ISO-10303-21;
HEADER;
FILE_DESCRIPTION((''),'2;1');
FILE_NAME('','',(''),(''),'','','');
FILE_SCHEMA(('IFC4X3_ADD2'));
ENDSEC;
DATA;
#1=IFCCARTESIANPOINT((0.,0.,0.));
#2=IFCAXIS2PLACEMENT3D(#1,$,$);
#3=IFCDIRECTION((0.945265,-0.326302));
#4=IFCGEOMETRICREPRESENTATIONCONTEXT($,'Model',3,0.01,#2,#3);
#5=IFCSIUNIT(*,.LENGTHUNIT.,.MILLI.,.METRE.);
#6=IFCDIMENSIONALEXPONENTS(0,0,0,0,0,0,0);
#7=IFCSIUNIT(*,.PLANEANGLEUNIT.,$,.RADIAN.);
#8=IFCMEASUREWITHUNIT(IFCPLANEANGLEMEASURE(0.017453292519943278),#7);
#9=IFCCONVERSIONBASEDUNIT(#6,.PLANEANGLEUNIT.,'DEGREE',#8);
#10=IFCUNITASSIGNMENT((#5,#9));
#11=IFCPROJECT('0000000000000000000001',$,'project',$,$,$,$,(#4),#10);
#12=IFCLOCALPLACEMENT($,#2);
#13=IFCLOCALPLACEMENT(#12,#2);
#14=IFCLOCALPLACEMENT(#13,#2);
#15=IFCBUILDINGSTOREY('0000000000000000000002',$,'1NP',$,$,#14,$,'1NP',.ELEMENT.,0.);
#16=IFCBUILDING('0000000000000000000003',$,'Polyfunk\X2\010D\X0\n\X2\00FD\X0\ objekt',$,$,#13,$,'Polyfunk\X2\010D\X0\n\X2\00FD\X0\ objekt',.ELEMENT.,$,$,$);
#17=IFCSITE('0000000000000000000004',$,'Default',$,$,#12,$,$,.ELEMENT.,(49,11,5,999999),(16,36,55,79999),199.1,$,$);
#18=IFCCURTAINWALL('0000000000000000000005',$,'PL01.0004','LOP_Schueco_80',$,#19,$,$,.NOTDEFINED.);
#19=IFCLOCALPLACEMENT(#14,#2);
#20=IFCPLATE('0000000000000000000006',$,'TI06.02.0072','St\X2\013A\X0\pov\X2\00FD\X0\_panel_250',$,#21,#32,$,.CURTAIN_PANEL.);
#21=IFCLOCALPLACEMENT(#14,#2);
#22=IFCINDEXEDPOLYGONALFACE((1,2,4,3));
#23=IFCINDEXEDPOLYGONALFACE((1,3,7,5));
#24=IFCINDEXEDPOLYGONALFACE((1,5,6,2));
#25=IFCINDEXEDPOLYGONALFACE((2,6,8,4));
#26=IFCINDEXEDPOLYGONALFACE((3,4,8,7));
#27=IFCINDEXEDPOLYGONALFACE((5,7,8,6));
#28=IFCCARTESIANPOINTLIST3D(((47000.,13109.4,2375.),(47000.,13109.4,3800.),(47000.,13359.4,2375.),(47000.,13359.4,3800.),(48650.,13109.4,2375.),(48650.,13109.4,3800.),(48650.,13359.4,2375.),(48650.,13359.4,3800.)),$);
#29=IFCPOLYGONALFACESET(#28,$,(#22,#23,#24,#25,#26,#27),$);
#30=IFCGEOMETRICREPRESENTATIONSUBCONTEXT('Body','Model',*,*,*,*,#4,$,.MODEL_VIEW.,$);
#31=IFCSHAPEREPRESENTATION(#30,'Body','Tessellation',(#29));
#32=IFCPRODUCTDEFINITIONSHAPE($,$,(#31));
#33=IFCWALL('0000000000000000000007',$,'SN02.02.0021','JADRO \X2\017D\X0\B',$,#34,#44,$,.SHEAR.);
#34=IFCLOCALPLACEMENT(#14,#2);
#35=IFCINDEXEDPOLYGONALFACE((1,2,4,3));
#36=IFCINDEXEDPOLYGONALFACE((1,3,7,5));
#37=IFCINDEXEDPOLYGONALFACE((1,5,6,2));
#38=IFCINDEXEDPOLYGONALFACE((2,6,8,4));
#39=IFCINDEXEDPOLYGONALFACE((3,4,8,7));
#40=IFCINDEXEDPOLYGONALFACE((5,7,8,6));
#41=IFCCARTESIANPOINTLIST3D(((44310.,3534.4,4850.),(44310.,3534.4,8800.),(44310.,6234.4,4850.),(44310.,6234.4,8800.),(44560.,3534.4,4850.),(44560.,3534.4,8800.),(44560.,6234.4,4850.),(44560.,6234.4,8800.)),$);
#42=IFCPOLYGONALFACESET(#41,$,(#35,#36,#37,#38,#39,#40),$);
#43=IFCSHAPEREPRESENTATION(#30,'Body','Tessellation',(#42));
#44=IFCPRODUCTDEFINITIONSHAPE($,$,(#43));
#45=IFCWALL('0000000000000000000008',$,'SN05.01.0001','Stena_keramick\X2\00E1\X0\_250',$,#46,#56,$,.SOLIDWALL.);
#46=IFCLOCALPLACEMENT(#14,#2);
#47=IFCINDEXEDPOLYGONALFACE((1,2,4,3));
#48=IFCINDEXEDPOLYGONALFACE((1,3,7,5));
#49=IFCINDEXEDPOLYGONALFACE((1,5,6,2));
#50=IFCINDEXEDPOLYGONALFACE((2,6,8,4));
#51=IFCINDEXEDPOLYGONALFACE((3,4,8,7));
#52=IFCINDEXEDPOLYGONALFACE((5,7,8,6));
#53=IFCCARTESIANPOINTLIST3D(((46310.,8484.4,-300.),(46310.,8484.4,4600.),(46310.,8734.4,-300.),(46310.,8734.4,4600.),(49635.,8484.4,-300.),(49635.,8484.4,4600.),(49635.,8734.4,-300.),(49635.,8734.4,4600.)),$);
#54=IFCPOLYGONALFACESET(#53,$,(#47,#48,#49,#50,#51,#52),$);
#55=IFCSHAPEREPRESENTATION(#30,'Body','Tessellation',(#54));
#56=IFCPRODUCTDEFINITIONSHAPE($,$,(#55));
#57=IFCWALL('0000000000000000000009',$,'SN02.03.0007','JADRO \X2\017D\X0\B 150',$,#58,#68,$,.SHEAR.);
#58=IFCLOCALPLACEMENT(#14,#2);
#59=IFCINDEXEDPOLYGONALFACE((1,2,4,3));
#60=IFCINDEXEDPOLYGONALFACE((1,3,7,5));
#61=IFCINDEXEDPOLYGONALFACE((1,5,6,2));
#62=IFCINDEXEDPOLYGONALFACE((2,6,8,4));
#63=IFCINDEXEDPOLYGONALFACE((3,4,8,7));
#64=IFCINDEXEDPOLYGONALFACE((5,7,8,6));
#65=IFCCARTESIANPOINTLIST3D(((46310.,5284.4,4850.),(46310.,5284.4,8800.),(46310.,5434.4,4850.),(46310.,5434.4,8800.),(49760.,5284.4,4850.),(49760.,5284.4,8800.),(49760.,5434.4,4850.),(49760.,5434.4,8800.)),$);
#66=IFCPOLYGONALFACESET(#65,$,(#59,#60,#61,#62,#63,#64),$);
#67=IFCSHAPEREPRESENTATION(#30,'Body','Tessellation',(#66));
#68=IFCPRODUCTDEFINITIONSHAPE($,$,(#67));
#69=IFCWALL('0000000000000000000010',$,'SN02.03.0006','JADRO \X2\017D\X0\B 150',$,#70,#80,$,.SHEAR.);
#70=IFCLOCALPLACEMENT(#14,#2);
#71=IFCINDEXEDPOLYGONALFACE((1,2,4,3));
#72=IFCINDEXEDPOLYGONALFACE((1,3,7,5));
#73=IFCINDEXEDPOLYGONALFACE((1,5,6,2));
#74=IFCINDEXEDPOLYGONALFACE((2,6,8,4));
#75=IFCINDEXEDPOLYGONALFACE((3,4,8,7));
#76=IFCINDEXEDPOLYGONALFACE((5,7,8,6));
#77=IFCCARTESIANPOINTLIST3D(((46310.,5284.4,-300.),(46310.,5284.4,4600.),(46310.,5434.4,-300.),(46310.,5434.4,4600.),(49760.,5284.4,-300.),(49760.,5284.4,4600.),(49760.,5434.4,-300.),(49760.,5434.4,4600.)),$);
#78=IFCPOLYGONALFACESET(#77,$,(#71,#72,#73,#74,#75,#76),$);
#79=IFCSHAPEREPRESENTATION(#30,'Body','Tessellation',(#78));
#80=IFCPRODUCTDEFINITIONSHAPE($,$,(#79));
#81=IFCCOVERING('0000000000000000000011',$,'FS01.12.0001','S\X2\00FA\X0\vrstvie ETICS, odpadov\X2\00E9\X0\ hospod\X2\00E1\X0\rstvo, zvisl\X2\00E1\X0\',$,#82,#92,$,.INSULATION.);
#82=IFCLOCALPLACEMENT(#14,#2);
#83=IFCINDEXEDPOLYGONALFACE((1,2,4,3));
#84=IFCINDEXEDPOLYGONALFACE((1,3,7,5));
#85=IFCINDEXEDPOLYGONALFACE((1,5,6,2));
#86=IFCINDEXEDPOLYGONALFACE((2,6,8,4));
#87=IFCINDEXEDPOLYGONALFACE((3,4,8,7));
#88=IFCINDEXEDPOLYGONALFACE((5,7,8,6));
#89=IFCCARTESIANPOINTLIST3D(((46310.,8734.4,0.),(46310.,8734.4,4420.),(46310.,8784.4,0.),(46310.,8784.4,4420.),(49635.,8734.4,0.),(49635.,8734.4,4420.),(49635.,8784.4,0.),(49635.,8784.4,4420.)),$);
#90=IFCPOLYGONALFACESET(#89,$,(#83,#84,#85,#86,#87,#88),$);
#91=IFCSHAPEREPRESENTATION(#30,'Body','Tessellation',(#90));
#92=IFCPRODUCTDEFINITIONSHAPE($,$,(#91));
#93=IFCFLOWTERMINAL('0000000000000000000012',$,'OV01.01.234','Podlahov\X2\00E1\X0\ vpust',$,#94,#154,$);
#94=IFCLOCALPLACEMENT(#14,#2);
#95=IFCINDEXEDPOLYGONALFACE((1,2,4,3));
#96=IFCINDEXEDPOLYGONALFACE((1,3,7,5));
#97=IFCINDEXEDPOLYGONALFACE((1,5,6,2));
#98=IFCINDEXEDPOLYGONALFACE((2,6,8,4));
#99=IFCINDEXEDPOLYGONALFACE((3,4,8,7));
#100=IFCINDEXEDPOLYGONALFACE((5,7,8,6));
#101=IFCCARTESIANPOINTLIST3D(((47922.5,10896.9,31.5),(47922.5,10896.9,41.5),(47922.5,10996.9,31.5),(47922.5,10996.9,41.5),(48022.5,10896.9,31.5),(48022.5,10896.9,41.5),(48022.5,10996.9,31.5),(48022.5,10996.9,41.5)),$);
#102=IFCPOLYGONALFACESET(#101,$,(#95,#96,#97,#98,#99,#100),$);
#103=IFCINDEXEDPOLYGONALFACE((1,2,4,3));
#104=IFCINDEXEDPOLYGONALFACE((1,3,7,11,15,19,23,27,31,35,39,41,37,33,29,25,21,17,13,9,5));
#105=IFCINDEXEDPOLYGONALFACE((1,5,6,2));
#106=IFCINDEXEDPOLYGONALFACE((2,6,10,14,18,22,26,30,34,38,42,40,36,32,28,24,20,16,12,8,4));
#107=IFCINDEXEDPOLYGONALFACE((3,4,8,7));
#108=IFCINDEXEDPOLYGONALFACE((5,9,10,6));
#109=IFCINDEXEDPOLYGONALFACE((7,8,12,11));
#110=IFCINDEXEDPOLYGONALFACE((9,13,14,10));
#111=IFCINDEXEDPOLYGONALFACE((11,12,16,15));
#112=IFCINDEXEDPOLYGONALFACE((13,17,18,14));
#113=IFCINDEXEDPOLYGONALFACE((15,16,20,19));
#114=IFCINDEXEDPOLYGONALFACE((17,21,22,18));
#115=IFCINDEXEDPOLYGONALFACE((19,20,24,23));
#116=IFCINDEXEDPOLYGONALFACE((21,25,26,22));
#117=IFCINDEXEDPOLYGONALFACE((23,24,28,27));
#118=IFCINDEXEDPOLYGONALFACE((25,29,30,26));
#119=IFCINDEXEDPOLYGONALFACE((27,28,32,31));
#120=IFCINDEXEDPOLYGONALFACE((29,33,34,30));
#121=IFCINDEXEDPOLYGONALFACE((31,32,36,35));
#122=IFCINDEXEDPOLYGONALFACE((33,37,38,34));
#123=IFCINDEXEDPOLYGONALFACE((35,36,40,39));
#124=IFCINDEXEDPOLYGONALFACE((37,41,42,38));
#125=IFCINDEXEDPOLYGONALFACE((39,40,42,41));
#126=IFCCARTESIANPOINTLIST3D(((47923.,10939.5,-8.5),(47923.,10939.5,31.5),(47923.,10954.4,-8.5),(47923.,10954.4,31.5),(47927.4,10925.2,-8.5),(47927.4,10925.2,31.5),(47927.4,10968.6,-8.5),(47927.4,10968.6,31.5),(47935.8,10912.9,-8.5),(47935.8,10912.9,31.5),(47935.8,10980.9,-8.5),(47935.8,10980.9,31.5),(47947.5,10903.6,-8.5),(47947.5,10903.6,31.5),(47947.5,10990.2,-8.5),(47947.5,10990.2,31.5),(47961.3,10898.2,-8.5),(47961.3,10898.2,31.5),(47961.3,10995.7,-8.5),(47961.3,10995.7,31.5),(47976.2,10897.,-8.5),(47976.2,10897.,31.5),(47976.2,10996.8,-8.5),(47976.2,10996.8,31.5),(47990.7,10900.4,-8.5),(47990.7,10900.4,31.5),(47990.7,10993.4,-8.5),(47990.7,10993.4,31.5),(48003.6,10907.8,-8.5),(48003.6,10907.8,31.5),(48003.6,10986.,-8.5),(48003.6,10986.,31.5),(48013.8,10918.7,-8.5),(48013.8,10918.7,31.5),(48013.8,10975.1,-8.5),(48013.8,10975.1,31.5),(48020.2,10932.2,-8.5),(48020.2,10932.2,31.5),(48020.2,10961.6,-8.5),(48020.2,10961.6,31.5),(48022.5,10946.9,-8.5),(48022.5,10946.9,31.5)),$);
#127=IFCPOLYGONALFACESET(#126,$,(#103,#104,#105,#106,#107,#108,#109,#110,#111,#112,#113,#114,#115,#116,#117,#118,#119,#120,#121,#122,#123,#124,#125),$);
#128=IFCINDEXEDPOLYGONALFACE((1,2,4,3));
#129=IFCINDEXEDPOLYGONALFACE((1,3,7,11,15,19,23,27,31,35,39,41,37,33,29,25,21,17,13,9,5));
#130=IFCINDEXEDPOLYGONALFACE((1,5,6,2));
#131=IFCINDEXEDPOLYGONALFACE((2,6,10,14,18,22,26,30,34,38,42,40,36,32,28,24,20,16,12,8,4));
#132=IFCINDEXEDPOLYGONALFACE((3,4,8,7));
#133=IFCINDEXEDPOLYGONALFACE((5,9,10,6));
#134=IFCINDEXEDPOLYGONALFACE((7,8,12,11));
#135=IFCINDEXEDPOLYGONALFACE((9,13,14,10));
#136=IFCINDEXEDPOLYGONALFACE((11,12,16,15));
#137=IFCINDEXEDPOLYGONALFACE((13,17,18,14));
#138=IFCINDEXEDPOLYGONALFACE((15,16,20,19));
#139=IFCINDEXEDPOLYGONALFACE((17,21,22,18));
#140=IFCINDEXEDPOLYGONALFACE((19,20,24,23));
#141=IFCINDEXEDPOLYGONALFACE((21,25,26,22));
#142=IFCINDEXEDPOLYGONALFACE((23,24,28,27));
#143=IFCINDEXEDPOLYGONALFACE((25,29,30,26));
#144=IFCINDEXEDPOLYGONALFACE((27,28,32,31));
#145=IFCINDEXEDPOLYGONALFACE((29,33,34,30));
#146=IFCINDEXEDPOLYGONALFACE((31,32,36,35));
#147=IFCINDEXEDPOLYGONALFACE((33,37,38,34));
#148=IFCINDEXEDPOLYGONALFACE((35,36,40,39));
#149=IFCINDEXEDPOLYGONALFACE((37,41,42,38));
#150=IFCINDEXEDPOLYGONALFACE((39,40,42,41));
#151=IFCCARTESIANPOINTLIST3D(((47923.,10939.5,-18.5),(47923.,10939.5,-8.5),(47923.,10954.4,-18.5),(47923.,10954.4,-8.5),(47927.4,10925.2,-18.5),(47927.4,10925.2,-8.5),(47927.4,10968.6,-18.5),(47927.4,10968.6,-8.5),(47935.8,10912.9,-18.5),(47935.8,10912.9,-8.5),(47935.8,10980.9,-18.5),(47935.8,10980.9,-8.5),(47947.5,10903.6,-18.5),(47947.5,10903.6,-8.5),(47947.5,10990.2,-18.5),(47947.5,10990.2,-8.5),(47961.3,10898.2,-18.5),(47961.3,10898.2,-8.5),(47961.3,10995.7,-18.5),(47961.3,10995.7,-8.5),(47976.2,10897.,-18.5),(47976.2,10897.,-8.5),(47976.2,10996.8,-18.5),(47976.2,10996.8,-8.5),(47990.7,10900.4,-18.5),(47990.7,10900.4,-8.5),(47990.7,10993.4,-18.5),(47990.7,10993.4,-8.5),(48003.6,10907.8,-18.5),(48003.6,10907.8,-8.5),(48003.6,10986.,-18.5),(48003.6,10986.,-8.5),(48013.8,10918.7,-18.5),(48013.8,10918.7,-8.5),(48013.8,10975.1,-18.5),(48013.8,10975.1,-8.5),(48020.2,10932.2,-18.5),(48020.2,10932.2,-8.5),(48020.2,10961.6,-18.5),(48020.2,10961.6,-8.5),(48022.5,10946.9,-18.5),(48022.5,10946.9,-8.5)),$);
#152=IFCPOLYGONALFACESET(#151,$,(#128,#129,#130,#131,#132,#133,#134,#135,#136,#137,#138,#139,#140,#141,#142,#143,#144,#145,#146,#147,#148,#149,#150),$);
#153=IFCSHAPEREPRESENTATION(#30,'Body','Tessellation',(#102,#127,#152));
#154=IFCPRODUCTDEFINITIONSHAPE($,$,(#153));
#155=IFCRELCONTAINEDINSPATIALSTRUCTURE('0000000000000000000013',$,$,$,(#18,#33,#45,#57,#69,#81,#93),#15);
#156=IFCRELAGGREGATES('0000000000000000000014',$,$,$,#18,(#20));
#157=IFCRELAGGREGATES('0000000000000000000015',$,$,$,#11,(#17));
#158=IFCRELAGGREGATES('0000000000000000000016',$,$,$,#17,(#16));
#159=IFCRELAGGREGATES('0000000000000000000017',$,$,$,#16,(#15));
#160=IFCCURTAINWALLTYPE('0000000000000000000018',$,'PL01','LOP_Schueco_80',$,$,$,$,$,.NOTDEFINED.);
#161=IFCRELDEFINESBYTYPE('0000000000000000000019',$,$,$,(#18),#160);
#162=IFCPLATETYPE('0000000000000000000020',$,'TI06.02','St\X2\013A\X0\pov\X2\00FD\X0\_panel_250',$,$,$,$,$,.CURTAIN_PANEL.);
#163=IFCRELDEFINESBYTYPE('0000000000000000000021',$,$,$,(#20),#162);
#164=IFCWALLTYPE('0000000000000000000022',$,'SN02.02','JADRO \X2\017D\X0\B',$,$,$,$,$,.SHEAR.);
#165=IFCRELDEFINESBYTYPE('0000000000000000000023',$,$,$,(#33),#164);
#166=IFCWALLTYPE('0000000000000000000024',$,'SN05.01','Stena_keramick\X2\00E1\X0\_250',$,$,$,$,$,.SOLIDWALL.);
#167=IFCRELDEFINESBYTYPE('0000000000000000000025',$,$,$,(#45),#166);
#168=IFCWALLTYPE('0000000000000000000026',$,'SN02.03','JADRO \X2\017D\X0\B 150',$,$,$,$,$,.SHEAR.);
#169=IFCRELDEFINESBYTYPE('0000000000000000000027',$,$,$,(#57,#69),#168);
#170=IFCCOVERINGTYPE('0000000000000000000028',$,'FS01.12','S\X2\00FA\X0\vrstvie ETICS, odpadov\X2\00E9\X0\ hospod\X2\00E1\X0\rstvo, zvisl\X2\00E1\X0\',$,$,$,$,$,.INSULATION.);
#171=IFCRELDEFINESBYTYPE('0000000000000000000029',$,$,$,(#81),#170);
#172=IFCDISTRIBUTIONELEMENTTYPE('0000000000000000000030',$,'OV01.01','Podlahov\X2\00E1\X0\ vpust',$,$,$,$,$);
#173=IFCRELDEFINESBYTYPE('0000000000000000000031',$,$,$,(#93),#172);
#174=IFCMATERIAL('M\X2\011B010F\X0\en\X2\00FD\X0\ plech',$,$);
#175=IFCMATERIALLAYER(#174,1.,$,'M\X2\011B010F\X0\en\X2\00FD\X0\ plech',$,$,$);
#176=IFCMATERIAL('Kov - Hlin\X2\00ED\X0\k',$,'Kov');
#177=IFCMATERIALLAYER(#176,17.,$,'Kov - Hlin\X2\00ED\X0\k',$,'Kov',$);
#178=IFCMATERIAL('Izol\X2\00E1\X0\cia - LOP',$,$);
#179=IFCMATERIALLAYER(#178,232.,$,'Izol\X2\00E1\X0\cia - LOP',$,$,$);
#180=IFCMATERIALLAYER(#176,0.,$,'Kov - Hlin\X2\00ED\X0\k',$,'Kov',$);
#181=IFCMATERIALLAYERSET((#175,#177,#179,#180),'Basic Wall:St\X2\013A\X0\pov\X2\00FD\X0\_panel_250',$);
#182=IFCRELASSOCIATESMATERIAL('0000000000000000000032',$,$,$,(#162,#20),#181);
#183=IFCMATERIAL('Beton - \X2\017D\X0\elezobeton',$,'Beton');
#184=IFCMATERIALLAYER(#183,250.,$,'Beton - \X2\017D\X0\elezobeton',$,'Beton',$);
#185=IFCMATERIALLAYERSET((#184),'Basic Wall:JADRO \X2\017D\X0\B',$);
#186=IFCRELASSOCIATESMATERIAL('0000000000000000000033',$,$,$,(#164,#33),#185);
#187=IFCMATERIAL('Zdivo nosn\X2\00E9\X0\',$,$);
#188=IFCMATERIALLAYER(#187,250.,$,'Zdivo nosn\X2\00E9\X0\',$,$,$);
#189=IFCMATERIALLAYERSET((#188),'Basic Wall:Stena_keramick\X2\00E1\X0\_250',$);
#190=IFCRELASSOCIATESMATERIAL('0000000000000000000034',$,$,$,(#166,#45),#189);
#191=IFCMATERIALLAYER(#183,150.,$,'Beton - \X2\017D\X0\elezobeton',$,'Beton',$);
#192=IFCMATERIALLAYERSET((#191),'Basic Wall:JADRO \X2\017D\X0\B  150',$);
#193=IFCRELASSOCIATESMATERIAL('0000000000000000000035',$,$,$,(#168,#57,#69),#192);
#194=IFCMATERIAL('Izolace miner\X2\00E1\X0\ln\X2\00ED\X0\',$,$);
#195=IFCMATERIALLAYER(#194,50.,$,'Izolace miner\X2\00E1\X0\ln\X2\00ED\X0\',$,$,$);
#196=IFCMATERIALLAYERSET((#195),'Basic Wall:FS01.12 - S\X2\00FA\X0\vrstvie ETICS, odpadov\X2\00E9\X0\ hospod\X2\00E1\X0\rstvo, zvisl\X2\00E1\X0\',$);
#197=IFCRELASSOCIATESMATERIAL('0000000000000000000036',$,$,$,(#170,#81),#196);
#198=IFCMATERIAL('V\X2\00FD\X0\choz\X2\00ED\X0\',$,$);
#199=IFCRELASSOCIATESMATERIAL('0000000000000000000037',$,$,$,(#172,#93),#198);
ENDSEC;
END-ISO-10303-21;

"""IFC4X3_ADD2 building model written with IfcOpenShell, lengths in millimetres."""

from ifc_helpers import new_model, entity, si_unit, converted_unit, direction, frame, frame_2d, origin, place, context, subcontext, project, spatial, polyline, rectangle, circle, extrude, clip, bounded_halfspace, source, transform, mapped, material, layer, layer_set, layer_usage, type_object, type_shapes, element, aggregate, save


model = new_model("IFC4X3_ADD2")

# Units and contexts
model_context = context("Model", 3, precision=0.01, world=origin(), true_north=direction((0.945265, -0.326302)))
body_context = subcontext(model_context, "Body", "Model", "MODEL_VIEW")
ifc_project = project(units=[si_unit("LENGTHUNIT", "METRE", prefix="MILLI"), converted_unit("PLANEANGLEUNIT", "DEGREE", entity("IfcPlaneAngleMeasure", 0.017453292519943278), si_unit("PLANEANGLEUNIT", "RADIAN"), dimensions=[0, 0, 0, 0, 0, 0, 0])], contexts=[model_context])

# Site, building, storey
site_placement = place(None, origin())
site = spatial("IfcSite", under=ifc_project, at=site_placement, Name="Default", CompositionType="ELEMENT", RefLatitude=(49, 11, 5, 999999), RefLongitude=(16, 36, 55, 79999), RefElevation=199.1)
building_placement = place(site_placement, origin())
building = spatial("IfcBuilding", under=site, at=building_placement, Name="Polyfunkčný objekt", LongName="Polyfunkčný objekt", CompositionType="ELEMENT")
storey_placement = place(building_placement, origin())
storey = spatial("IfcBuildingStorey", under=building, at=storey_placement, Name="1NP", LongName="1NP", CompositionType="ELEMENT", Elevation=0.0)

# Curtain wall, plate
curtain_wall_type = type_object("IfcCurtainWallType", Name="PL01", Description="LOP_Schueco_80", PredefinedType="NOTDEFINED")
curtain_wall_placement = place(storey_placement, origin())
curtain_wall = element("IfcCurtainWall", 1, at=curtain_wall_placement, inside=storey, type_object=curtain_wall_type, Name="PL01.0004", Description="LOP_Schueco_80", PredefinedType="NOTDEFINED")
ifc_material_1 = material(Name="Měďený plech")
ifc_layer_1 = layer(ifc_material_1, 1.0, Name="Měďený plech")
ifc_material_2 = material(Name="Kov - Hliník", Category="Kov")
ifc_layer_2 = layer(ifc_material_2, 17.0, Name="Kov - Hliník", Category="Kov")
ifc_material_3 = material(Name="Izolácia - LOP")
ifc_layer_3 = layer(ifc_material_3, 232.0, Name="Izolácia - LOP")
ifc_layer_4 = layer(ifc_material_2, 0.0, Name="Kov - Hliník", Category="Kov")
ifc_layer_set_1 = layer_set([ifc_layer_1, ifc_layer_2, ifc_layer_3, ifc_layer_4], Name="Basic Wall:Stĺpový_panel_250")
ifc_layer_usage = layer_usage(ifc_layer_set_1, "AXIS2", "NEGATIVE", 125.0)
plate_type = type_object("IfcPlateType", Name="TI06.02", Description="Stĺpový_panel_250", PredefinedType="CURTAIN_PANEL", material=ifc_layer_set_1)
plate_placement = place(storey_placement, frame((47000.0, 13234.4, 2375.0)))
plate = element("IfcPlate", 2, at=plate_placement, type_object=plate_type, material=ifc_layer_usage, Name="TI06.02.0072", Description="Stĺpový_panel_250", PredefinedType="CURTAIN_PANEL", context=body_context, shape_type="SweptSolid", body=[
    extrude(rectangle(XDim=250.0, YDim=1650.0, at=frame_2d((0.0, 0.0), x_axis=(1.0, 0.0))), frame((825.0, 0.0, 0.0), z_axis=(0.0, 0.0, 1.0), x_axis=(0.0, 1.0, 0.0)), (0.0, 0.0, 1.0), 1425.0),
])
aggregate(curtain_wall, [plate])

# Walls
ifc_material_4 = material(Name="Beton - Železobeton", Category="Beton")
ifc_layer_5 = layer(ifc_material_4, 250.0, Name="Beton - Železobeton", Category="Beton")
ifc_layer_set_2 = layer_set([ifc_layer_5], Name="Basic Wall:JADRO ŽB")
wall_type_1 = type_object("IfcWallType", Name="SN02.02", Description="JADRO ŽB", PredefinedType="SHEAR", material=ifc_layer_set_2)
wall_1_placement = place(storey_placement, frame((44435.0, 6234.4, 4850.0), z_axis=(0.0, 0.0, 1.0), x_axis=(0.0, -1.0, 0.0)))
element("IfcWall", 3, at=wall_1_placement, inside=storey, type_object=wall_type_1, material=ifc_layer_set_2, Name="SN02.02.0021", Description="JADRO ŽB", PredefinedType="SHEAR", context=body_context, shape_type="Clipping", body=[
    clip(clip(extrude(rectangle(XDim=2700.0, YDim=250.0, at=frame_2d((1350.0, 0.0), x_axis=(-1.0, 0.0))), origin(), (0.0, 0.0, 1.0), 3950.0), bounded_halfspace(frame((2700.0, -125.0, 0.0), z_axis=(0.0, 0.0, 1.0), x_axis=(0.0, -1.0, 0.0)), True, frame((2700.0, -125.0, 0.0)), polyline([(0.0, 0.0), (0.0, 250.0), (-2700.0, 250.0), (-2700.0, 0.0), (0.0, 0.0)]))), bounded_halfspace(frame((0.0, -125.0, 3950.0), z_axis=(0.0, 0.0, -1.0), x_axis=(0.0, 1.0, 0.0)), True, frame((0.0, -125.0, 3950.0)), polyline([(0.0, 0.0), (2700.0, 0.0), (2700.0, 250.0), (0.0, 250.0), (0.0, 0.0)]))),
])
ifc_material_5 = material(Name="Zdivo nosné")
ifc_layer_6 = layer(ifc_material_5, 250.0, Name="Zdivo nosné")
ifc_layer_set_3 = layer_set([ifc_layer_6], Name="Basic Wall:Stena_keramická_250")
wall_type_2 = type_object("IfcWallType", Name="SN05.01", Description="Stena_keramická_250", PredefinedType="SOLIDWALL", material=ifc_layer_set_3)
wall_2_placement = place(storey_placement, frame((46310.0, 8609.4, -300.0)))
element("IfcWall", 4, at=wall_2_placement, inside=storey, type_object=wall_type_2, material=ifc_layer_set_3, Name="SN05.01.0001", Description="Stena_keramická_250", PredefinedType="SOLIDWALL", context=body_context, shape_type="Clipping", body=[
    clip(clip(extrude(rectangle(XDim=3325.0, YDim=250.0, at=frame_2d((1662.5, 0.0), x_axis=(-1.0, 0.0))), origin(), (0.0, 0.0, 1.0), 4900.0), bounded_halfspace(frame((0.0, -125.0, 4900.0), z_axis=(0.0, 0.0, -1.0), x_axis=(1.0, 0.0, 0.0)), True, frame((0.0, -125.0, 4900.0)), polyline([(0.0, 0.0), (3325.0, 0.0), (3325.0, 250.0), (0.0, 250.0), (0.0, 0.0)]))), bounded_halfspace(frame((3325.0, -125.0, 0.0), z_axis=(0.0, 0.0, 1.0), x_axis=(0.0, 1.0, 0.0)), True, frame((3325.0, -125.0, 0.0)), polyline([(0.0, 0.0), (0.0, 250.0), (-3325.0, 250.0), (-3325.0, 0.0), (0.0, 0.0)]))),
])
ifc_layer_7 = layer(ifc_material_4, 150.0, Name="Beton - Železobeton", Category="Beton")
ifc_layer_set_4 = layer_set([ifc_layer_7], Name="Basic Wall:JADRO ŽB  150")
wall_type_3 = type_object("IfcWallType", Name="SN02.03", Description="JADRO ŽB 150", PredefinedType="SHEAR", material=ifc_layer_set_4)
wall_3_placement = place(storey_placement, frame((46310.0, 5359.4, 4850.0)))
element("IfcWall", 5, at=wall_3_placement, inside=storey, type_object=wall_type_3, material=ifc_layer_set_4, Name="SN02.03.0007", Description="JADRO ŽB 150", PredefinedType="SHEAR", context=body_context, shape_type="SweptSolid", body=[
    extrude(rectangle(XDim=3450.0, YDim=150.0, at=frame_2d((1725.0, 0.0), x_axis=(-1.0, 0.0))), origin(), (0.0, 0.0, 1.0), 3950.0),
])
wall_4_placement = place(storey_placement, frame((46310.0, 5359.4, -300.0)))
element("IfcWall", 6, at=wall_4_placement, inside=storey, type_object=wall_type_3, material=ifc_layer_set_4, Name="SN02.03.0006", Description="JADRO ŽB 150", PredefinedType="SHEAR", context=body_context, shape_type="SweptSolid", body=[
    extrude(rectangle(XDim=3450.0, YDim=150.0, at=frame_2d((1725.0, 0.0), x_axis=(-1.0, 0.0))), origin(), (0.0, 0.0, 1.0), 4900.0),
])

# Covering
ifc_material_6 = material(Name="Izolace minerální")
ifc_layer_8 = layer(ifc_material_6, 50.0, Name="Izolace minerální")
ifc_layer_set_5 = layer_set([ifc_layer_8], Name="Basic Wall:FS01.12 - Súvrstvie ETICS, odpadové hospodárstvo, zvislá")
covering_type = type_object("IfcCoveringType", Name="FS01.12", Description="Súvrstvie ETICS, odpadové hospodárstvo, zvislá", PredefinedType="INSULATION", material=ifc_layer_set_5)
covering_placement = place(storey_placement, frame((46310.0, 8759.4, 0.0)))
element("IfcCovering", 7, at=covering_placement, inside=storey, type_object=covering_type, material=ifc_layer_set_5, Name="FS01.12.0001", Description="Súvrstvie ETICS, odpadové hospodárstvo, zvislá", PredefinedType="INSULATION", context=body_context, shape_type="SweptSolid", body=[
    extrude(rectangle(XDim=3325.0, YDim=50.0, at=frame_2d((1662.5, 0.0), x_axis=(-1.0, 0.0))), origin(), (0.0, 0.0, 1.0), 4420.0),
])

# Flow terminal
ifc_material_7 = material(Name="Výchozí")
distribution_element_type = type_object("IfcDistributionElementType", Name="OV01.01", Description="Podlahová vpust", material=ifc_material_7)
shared_shape_1 = source(origin(), body_context, "Body", "SweptSolid", [
    extrude(rectangle(XDim=100.0, YDim=100.0, at=frame_2d((0.0, 0.0), x_axis=(1.0, 0.0))), frame((0.0, 0.0, -10.0), z_axis=(0.0, 0.0, 1.0), x_axis=(-1.0, 0.0, 0.0)), (0.0, 0.0, 1.0), 10.0),
    extrude(circle(Radius=50.0, at=frame_2d((0.0, 0.0), x_axis=(1.0, 0.0))), frame((0.0, 0.0, -50.0)), (0.0, 0.0, 1.0), 40.0),
    extrude(circle(Radius=50.0, at=frame_2d((0.0, 0.0), x_axis=(1.0, 0.0))), frame((0.0, 0.0, -60.0)), (0.0, 0.0, 1.0), 10.0),
])
type_shapes(distribution_element_type, [shared_shape_1])
flow_terminal_placement = place(storey_placement, frame((47972.5, 10946.9, 41.5)))
element("IfcFlowTerminal", 8, at=flow_terminal_placement, inside=storey, type_object=distribution_element_type, material=ifc_material_7, Name="OV01.01.234", Description="Podlahová vpust", context=body_context, shape_type="MappedRepresentation", body=[
    mapped(shared_shape_1, transform((0.0, 0.0, 0.0), scale=1.0)),
])

save(model, "model.ifc")
